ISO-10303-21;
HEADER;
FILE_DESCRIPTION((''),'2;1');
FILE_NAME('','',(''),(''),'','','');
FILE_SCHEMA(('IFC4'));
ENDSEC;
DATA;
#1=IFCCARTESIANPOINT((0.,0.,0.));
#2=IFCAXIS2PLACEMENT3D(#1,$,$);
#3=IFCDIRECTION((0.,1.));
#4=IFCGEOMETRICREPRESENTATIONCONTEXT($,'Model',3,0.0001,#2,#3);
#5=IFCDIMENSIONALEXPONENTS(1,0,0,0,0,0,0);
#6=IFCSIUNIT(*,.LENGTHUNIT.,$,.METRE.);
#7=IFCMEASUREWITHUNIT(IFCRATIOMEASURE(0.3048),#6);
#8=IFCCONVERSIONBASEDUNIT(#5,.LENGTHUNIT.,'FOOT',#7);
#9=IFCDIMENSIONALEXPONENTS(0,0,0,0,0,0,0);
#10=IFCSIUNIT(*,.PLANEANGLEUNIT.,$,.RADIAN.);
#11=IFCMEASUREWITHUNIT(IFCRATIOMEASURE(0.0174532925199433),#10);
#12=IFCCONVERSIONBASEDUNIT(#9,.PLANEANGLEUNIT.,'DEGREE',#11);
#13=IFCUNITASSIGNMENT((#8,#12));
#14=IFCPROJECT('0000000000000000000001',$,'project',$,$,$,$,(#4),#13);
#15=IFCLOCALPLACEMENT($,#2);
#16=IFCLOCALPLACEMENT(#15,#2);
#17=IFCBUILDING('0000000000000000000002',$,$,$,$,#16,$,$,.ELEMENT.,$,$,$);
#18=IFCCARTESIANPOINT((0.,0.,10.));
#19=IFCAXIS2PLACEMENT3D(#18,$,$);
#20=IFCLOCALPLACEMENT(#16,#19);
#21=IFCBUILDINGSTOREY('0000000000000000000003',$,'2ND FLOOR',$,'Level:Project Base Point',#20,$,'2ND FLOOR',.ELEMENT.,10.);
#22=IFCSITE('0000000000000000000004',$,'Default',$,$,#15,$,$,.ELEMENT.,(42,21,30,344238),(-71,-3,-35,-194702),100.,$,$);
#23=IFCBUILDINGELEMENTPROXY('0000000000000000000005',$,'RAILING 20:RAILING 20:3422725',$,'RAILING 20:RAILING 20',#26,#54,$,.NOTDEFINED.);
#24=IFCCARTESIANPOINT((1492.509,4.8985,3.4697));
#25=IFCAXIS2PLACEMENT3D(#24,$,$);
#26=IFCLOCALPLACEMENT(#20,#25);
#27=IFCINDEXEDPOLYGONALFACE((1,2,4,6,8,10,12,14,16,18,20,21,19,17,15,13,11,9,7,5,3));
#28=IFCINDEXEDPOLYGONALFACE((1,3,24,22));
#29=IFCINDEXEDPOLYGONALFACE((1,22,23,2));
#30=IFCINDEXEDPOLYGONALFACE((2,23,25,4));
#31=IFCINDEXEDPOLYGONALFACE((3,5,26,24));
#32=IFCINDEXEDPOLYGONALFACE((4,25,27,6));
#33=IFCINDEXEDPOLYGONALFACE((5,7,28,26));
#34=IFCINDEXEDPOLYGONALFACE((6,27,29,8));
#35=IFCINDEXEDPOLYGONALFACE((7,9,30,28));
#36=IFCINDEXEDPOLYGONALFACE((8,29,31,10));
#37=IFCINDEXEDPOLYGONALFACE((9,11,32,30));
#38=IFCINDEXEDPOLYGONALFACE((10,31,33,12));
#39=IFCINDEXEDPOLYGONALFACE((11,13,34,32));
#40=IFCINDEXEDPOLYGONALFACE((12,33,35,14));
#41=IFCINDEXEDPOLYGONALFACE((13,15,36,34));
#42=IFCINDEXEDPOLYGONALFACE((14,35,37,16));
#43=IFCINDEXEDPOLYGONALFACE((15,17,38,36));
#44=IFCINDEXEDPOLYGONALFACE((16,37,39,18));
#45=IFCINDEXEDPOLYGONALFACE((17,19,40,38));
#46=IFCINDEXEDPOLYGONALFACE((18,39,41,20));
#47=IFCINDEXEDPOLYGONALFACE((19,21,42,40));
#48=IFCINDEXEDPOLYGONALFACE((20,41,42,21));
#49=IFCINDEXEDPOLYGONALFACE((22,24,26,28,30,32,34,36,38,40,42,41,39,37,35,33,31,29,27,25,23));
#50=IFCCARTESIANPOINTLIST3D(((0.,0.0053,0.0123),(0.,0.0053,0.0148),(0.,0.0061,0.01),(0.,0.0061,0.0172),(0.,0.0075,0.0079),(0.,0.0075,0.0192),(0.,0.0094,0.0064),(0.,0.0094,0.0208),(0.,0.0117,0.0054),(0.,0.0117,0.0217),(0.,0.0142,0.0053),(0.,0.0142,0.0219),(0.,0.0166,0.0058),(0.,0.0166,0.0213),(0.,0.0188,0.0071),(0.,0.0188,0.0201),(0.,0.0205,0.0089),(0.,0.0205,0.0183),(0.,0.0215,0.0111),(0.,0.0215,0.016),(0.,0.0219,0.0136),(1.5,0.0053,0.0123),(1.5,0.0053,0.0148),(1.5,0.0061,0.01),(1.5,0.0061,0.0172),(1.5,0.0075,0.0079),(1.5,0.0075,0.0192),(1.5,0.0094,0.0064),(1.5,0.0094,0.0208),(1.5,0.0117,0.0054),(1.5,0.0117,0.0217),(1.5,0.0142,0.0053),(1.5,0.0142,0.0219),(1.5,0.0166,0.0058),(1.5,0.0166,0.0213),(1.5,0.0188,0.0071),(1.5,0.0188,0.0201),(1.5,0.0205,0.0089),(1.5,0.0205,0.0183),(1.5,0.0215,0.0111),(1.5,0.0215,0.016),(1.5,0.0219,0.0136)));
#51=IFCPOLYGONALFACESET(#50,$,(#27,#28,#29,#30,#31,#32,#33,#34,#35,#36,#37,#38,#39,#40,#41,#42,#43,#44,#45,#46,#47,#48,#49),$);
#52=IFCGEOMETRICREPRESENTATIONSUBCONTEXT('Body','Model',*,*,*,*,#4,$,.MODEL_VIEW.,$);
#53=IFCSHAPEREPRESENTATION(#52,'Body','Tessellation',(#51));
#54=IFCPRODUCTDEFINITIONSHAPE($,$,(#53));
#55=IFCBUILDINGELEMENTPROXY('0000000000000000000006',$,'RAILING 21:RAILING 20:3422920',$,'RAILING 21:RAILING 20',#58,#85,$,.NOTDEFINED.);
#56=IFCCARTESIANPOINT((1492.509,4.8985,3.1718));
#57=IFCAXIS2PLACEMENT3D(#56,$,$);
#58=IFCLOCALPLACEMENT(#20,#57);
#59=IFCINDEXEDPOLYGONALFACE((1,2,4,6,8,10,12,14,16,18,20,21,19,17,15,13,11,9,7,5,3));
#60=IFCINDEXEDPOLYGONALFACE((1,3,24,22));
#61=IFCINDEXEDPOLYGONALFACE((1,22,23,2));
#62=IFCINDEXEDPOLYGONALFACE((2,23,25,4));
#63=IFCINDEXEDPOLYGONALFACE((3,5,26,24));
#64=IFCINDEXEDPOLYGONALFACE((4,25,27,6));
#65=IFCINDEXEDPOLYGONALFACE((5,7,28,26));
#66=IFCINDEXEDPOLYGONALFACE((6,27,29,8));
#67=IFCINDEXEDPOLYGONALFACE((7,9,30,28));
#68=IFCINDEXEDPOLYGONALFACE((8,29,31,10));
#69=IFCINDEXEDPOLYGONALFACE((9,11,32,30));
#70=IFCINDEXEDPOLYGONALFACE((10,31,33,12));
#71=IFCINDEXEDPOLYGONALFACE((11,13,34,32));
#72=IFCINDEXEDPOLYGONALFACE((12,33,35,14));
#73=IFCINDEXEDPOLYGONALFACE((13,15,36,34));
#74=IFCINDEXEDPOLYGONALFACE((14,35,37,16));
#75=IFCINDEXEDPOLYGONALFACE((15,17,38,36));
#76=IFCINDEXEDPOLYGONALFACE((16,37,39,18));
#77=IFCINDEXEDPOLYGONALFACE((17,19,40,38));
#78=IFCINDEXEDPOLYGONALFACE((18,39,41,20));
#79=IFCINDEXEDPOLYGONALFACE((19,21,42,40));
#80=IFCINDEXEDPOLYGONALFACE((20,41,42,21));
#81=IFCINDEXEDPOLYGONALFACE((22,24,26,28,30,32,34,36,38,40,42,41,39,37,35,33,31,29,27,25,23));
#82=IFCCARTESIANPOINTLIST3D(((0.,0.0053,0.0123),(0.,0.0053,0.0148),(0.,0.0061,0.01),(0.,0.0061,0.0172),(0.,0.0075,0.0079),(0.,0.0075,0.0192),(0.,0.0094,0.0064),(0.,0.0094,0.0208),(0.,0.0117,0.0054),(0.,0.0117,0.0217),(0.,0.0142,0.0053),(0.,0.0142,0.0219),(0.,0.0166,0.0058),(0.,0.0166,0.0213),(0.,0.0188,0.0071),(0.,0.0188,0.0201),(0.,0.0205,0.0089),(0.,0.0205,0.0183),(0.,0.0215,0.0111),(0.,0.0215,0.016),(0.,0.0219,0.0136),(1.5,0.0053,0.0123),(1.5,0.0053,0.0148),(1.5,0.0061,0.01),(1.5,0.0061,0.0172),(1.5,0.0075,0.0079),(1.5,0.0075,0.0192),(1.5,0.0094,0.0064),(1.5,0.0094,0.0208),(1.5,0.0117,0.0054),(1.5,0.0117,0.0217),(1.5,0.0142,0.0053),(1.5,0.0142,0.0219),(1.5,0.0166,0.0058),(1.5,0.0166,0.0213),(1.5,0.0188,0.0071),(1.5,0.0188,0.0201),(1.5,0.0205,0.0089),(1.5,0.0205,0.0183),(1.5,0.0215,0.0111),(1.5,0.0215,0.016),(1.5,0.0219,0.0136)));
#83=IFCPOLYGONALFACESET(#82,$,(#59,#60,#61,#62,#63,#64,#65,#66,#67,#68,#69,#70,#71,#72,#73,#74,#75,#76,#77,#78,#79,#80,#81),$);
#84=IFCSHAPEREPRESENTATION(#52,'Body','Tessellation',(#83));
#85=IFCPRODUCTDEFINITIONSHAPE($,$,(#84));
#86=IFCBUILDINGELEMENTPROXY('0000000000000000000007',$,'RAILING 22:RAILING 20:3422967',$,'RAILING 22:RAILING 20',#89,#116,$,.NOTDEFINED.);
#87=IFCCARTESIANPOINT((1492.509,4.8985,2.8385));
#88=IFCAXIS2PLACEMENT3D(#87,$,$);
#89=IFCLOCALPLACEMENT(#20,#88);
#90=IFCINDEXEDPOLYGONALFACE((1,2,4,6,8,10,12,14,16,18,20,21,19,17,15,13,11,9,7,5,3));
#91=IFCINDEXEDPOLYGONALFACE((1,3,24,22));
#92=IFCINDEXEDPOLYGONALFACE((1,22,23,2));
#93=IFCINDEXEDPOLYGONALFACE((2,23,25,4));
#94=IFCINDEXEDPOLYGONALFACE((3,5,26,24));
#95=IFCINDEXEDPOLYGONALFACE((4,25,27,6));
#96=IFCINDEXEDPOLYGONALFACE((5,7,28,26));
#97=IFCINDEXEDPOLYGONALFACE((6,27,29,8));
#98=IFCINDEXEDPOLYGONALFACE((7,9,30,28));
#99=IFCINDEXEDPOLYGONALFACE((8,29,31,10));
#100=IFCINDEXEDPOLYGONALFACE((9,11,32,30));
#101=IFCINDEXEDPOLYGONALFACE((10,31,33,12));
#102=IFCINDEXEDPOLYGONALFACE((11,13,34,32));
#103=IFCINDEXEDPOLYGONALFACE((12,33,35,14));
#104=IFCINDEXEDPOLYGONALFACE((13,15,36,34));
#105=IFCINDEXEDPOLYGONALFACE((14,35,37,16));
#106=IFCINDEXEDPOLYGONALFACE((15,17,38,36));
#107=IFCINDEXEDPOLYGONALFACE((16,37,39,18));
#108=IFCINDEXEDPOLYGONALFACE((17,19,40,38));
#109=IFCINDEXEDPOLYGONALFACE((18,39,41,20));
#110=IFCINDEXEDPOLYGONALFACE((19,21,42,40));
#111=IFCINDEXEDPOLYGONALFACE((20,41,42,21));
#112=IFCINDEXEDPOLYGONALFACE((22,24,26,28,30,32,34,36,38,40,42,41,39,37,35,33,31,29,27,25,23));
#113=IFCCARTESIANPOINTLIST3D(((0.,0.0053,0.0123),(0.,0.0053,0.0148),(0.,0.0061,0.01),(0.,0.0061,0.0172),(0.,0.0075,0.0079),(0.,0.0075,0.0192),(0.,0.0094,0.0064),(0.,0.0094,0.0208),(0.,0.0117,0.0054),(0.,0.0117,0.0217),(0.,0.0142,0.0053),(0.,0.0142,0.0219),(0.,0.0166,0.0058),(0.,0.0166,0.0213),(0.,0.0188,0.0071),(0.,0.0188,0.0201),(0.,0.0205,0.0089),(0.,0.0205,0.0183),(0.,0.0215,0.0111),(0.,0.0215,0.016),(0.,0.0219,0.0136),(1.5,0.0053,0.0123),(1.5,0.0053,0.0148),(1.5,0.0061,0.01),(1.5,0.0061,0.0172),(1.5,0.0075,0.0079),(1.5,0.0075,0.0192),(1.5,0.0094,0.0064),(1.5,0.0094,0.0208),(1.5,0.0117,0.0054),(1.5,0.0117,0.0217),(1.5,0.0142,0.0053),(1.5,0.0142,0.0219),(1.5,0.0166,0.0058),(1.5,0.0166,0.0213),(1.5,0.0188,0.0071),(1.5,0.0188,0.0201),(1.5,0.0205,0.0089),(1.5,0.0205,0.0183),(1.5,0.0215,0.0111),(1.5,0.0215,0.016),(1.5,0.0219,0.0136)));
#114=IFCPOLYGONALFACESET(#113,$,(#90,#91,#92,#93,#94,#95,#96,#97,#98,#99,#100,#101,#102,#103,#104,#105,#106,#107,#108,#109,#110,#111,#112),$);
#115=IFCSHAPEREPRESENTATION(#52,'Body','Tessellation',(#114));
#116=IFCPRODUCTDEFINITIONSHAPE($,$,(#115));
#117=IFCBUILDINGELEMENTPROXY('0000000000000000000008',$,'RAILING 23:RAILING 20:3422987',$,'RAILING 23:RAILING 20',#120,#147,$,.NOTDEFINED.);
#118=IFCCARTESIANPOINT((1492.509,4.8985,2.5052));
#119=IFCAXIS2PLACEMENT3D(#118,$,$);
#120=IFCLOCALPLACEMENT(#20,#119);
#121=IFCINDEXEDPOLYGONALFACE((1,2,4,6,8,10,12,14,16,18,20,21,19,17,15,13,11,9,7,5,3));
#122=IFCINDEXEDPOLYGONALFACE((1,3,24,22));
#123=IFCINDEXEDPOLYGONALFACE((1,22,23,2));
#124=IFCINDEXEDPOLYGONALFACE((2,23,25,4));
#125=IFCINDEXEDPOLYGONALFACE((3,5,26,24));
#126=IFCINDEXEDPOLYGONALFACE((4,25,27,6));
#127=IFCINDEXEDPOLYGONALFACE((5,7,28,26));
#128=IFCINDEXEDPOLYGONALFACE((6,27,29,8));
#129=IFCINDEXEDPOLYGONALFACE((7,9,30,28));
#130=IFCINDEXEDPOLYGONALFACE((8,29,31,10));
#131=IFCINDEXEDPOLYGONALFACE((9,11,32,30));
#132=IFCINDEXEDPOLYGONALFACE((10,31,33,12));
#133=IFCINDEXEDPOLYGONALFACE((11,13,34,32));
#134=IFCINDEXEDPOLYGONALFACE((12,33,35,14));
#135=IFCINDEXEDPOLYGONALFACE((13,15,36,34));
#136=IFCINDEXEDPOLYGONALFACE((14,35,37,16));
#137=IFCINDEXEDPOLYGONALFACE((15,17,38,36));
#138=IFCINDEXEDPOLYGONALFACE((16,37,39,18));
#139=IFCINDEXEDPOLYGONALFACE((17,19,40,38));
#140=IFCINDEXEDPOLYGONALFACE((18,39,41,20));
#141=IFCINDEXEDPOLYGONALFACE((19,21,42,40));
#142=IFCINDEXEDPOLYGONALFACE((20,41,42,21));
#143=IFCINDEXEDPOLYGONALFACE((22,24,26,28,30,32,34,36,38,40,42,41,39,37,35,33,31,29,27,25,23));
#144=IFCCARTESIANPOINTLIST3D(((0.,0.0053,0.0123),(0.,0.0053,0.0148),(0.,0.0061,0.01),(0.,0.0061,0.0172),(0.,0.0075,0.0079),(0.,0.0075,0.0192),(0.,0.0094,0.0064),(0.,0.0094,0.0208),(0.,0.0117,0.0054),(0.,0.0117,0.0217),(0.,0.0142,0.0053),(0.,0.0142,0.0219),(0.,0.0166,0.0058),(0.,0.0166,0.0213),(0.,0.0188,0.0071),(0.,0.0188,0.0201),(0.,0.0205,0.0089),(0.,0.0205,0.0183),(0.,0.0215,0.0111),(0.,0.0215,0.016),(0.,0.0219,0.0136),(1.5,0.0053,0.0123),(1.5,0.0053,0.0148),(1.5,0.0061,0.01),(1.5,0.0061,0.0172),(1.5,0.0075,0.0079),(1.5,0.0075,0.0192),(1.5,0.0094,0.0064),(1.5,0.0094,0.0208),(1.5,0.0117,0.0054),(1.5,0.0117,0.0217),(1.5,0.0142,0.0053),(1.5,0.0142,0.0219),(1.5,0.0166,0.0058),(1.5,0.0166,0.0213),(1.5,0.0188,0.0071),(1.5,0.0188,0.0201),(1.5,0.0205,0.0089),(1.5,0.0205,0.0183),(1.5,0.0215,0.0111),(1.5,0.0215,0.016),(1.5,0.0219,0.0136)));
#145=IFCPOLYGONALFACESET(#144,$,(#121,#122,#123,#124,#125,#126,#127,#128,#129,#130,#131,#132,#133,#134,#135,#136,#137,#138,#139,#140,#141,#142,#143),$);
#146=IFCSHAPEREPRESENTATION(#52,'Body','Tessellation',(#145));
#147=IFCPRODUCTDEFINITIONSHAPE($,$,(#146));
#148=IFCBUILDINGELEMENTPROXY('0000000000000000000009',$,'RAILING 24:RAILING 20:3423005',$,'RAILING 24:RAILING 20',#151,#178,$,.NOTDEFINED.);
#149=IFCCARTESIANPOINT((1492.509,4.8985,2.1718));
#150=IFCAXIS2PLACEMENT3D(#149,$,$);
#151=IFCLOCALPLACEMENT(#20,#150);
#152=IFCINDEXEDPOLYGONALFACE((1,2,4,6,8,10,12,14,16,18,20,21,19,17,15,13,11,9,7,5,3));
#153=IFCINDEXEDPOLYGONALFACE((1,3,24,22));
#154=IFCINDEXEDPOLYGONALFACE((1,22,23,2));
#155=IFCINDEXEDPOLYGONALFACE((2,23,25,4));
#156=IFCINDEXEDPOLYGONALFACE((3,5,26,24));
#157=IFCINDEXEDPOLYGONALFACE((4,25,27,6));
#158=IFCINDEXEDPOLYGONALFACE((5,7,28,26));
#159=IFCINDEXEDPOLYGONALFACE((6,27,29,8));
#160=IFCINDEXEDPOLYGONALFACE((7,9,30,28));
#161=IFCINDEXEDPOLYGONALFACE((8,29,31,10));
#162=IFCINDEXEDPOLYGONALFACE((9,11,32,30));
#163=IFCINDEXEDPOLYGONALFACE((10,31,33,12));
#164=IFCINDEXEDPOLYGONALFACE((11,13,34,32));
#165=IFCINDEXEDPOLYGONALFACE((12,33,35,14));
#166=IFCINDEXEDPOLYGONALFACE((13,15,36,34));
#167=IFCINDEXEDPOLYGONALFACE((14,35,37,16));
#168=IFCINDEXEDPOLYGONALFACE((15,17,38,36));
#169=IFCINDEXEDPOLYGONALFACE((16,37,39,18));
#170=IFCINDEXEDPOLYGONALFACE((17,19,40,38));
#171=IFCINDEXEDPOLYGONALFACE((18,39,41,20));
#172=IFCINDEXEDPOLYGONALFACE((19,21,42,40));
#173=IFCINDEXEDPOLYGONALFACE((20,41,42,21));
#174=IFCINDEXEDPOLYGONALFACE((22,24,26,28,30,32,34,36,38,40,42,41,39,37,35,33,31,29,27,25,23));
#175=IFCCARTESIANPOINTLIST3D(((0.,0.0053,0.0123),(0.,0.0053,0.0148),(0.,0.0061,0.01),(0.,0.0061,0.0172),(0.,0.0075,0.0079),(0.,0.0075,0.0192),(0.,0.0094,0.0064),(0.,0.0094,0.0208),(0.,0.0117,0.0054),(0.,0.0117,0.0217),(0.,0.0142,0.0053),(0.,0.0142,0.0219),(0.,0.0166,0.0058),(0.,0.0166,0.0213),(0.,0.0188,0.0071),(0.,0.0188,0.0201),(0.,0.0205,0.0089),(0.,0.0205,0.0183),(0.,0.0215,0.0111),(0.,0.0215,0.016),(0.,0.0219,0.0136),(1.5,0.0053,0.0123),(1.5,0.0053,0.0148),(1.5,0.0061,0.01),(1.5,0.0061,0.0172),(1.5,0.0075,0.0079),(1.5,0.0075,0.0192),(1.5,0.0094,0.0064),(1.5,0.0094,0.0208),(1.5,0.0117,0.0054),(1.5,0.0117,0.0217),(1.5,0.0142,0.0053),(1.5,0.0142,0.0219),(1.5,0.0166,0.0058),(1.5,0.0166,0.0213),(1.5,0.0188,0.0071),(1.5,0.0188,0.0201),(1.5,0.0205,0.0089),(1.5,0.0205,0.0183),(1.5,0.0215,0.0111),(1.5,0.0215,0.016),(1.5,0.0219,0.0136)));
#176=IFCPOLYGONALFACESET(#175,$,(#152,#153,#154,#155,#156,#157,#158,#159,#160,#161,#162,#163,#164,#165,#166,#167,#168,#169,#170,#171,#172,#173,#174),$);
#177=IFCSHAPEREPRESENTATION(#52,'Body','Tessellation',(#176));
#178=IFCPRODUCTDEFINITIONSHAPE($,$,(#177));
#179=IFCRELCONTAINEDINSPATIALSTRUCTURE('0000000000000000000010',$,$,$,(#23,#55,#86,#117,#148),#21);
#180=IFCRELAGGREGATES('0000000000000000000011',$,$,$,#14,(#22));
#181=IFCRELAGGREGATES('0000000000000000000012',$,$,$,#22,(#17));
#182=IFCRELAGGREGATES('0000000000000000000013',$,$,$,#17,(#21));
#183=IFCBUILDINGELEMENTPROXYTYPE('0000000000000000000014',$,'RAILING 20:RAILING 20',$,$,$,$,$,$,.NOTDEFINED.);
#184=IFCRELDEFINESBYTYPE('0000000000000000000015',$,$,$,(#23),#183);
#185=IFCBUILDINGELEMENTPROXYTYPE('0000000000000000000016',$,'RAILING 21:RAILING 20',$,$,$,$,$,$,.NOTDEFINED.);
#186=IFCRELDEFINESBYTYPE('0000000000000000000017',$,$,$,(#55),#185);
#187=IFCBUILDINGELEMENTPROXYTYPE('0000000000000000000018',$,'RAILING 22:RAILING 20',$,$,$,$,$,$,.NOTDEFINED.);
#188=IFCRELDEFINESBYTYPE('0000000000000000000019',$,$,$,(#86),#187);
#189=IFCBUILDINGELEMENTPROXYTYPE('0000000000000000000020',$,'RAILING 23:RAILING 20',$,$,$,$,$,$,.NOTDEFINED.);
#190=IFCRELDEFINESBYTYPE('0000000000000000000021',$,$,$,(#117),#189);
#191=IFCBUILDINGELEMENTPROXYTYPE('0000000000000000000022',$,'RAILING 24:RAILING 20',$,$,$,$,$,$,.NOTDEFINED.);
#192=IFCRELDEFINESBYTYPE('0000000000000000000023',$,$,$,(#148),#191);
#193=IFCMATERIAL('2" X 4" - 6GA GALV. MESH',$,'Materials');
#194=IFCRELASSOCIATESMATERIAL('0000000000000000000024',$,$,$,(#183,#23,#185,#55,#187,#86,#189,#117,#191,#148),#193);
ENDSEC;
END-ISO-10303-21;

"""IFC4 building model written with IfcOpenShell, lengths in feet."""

from ifc_helpers import new_model, entity, si_unit, converted_unit, direction, frame, origin, origin_2d_with_axis, place, context, subcontext, project, spatial, circle, extrude, source, transform, mapped, material, type_object, type_shapes, element, save


model = new_model("IFC4")

# Units and contexts
model_context = context("Model", 3, precision=0.0001, world=origin(), true_north=direction((0.0, 1.0)))
body_context = subcontext(model_context, "Body", "Model", "MODEL_VIEW")
ifc_project = project(units=[converted_unit("LENGTHUNIT", "FOOT", entity("IfcRatioMeasure", 0.3048), si_unit("LENGTHUNIT", "METRE"), dimensions=[1, 0, 0, 0, 0, 0, 0]), converted_unit("PLANEANGLEUNIT", "DEGREE", entity("IfcRatioMeasure", 0.0174532925199433), si_unit("PLANEANGLEUNIT", "RADIAN"), dimensions=[0, 0, 0, 0, 0, 0, 0])], contexts=[model_context])

# Site, building, storey
site_placement = place(None, origin())
site = spatial("IfcSite", under=ifc_project, at=site_placement, Name="Default", CompositionType="ELEMENT", RefLatitude=(42, 21, 30, 344238), RefLongitude=(-71, -3, -35, -194702), RefElevation=100.0)
building_placement = place(site_placement, origin())
building = spatial("IfcBuilding", under=site, at=building_placement, CompositionType="ELEMENT")
storey_placement = place(building_placement, frame((0.0, 0.0, 10.0)))
storey = spatial("IfcBuildingStorey", under=building, at=storey_placement, Name="2ND FLOOR", ObjectType="Level:Project Base Point", LongName="2ND FLOOR", CompositionType="ELEMENT", Elevation=10.0)

# Building element proxies
ifc_material_1 = material(Name="2\" X 4\" - 6GA GALV. MESH", Category="Materials")
building_element_proxy_type_1 = type_object("IfcBuildingElementProxyType", Name="RAILING 20:RAILING 20", PredefinedType="NOTDEFINED", material=ifc_material_1)
shared_shape_1 = source(origin(), body_context, "Body", "SweptSolid", [
    extrude(circle(Radius=0.0083, at=origin_2d_with_axis()), frame((0.0, 0.0136, 0.0136), z_axis=(1.0, 0.0, 0.0), x_axis=(0.0, 1.0, 0.0)), (0.0, 0.0, 1.0), 1.5),
])
type_shapes(building_element_proxy_type_1, [shared_shape_1])
proxy_1_placement = place(storey_placement, frame((1492.509, 4.8985, 3.4697)))
element("IfcBuildingElementProxy", 1, at=proxy_1_placement, inside=storey, type_object=building_element_proxy_type_1, material=ifc_material_1, Name="RAILING 20:RAILING 20:3422725", ObjectType="RAILING 20:RAILING 20", PredefinedType="NOTDEFINED", context=body_context, shape_type="MappedRepresentation", body=[
    mapped(shared_shape_1, transform((0.0, 0.0, 0.0), scale=1.0)),
])
building_element_proxy_type_2 = type_object("IfcBuildingElementProxyType", Name="RAILING 21:RAILING 20", PredefinedType="NOTDEFINED", material=ifc_material_1)
shared_shape_2 = source(origin(), body_context, "Body", "SweptSolid", [
    extrude(circle(Radius=0.0083, at=origin_2d_with_axis()), frame((0.0, 0.0136, 0.0136), z_axis=(1.0, 0.0, 0.0), x_axis=(0.0, 1.0, 0.0)), (0.0, 0.0, 1.0), 1.5),
])
type_shapes(building_element_proxy_type_2, [shared_shape_2])
proxy_2_placement = place(storey_placement, frame((1492.509, 4.8985, 3.1718)))
element("IfcBuildingElementProxy", 2, at=proxy_2_placement, inside=storey, type_object=building_element_proxy_type_2, material=ifc_material_1, Name="RAILING 21:RAILING 20:3422920", ObjectType="RAILING 21:RAILING 20", PredefinedType="NOTDEFINED", context=body_context, shape_type="MappedRepresentation", body=[
    mapped(shared_shape_2, transform((0.0, 0.0, 0.0), scale=1.0)),
])
building_element_proxy_type_3 = type_object("IfcBuildingElementProxyType", Name="RAILING 22:RAILING 20", PredefinedType="NOTDEFINED", material=ifc_material_1)
shared_shape_3 = source(origin(), body_context, "Body", "SweptSolid", [
    extrude(circle(Radius=0.0083, at=origin_2d_with_axis()), frame((0.0, 0.0136, 0.0136), z_axis=(1.0, 0.0, 0.0), x_axis=(0.0, 1.0, 0.0)), (0.0, 0.0, 1.0), 1.5),
])
type_shapes(building_element_proxy_type_3, [shared_shape_3])
proxy_3_placement = place(storey_placement, frame((1492.509, 4.8985, 2.8385)))
element("IfcBuildingElementProxy", 3, at=proxy_3_placement, inside=storey, type_object=building_element_proxy_type_3, material=ifc_material_1, Name="RAILING 22:RAILING 20:3422967", ObjectType="RAILING 22:RAILING 20", PredefinedType="NOTDEFINED", context=body_context, shape_type="MappedRepresentation", body=[
    mapped(shared_shape_3, transform((0.0, 0.0, 0.0), scale=1.0)),
])
building_element_proxy_type_4 = type_object("IfcBuildingElementProxyType", Name="RAILING 23:RAILING 20", PredefinedType="NOTDEFINED", material=ifc_material_1)
shared_shape_4 = source(origin(), body_context, "Body", "SweptSolid", [
    extrude(circle(Radius=0.0083, at=origin_2d_with_axis()), frame((0.0, 0.0136, 0.0136), z_axis=(1.0, 0.0, 0.0), x_axis=(0.0, 1.0, 0.0)), (0.0, 0.0, 1.0), 1.5),
])
type_shapes(building_element_proxy_type_4, [shared_shape_4])
proxy_4_placement = place(storey_placement, frame((1492.509, 4.8985, 2.5052)))
element("IfcBuildingElementProxy", 4, at=proxy_4_placement, inside=storey, type_object=building_element_proxy_type_4, material=ifc_material_1, Name="RAILING 23:RAILING 20:3422987", ObjectType="RAILING 23:RAILING 20", PredefinedType="NOTDEFINED", context=body_context, shape_type="MappedRepresentation", body=[
    mapped(shared_shape_4, transform((0.0, 0.0, 0.0), scale=1.0)),
])
building_element_proxy_type_5 = type_object("IfcBuildingElementProxyType", Name="RAILING 24:RAILING 20", PredefinedType="NOTDEFINED", material=ifc_material_1)
shared_shape_5 = source(origin(), body_context, "Body", "SweptSolid", [
    extrude(circle(Radius=0.0083, at=origin_2d_with_axis()), frame((0.0, 0.0136, 0.0136), z_axis=(1.0, 0.0, 0.0), x_axis=(0.0, 1.0, 0.0)), (0.0, 0.0, 1.0), 1.5),
])
type_shapes(building_element_proxy_type_5, [shared_shape_5])
proxy_5_placement = place(storey_placement, frame((1492.509, 4.8985, 2.1718)))
element("IfcBuildingElementProxy", 5, at=proxy_5_placement, inside=storey, type_object=building_element_proxy_type_5, material=ifc_material_1, Name="RAILING 24:RAILING 20:3423005", ObjectType="RAILING 24:RAILING 20", PredefinedType="NOTDEFINED", context=body_context, shape_type="MappedRepresentation", body=[
    mapped(shared_shape_5, transform((0.0, 0.0, 0.0), scale=1.0)),
])

save(model, "model.ifc")
